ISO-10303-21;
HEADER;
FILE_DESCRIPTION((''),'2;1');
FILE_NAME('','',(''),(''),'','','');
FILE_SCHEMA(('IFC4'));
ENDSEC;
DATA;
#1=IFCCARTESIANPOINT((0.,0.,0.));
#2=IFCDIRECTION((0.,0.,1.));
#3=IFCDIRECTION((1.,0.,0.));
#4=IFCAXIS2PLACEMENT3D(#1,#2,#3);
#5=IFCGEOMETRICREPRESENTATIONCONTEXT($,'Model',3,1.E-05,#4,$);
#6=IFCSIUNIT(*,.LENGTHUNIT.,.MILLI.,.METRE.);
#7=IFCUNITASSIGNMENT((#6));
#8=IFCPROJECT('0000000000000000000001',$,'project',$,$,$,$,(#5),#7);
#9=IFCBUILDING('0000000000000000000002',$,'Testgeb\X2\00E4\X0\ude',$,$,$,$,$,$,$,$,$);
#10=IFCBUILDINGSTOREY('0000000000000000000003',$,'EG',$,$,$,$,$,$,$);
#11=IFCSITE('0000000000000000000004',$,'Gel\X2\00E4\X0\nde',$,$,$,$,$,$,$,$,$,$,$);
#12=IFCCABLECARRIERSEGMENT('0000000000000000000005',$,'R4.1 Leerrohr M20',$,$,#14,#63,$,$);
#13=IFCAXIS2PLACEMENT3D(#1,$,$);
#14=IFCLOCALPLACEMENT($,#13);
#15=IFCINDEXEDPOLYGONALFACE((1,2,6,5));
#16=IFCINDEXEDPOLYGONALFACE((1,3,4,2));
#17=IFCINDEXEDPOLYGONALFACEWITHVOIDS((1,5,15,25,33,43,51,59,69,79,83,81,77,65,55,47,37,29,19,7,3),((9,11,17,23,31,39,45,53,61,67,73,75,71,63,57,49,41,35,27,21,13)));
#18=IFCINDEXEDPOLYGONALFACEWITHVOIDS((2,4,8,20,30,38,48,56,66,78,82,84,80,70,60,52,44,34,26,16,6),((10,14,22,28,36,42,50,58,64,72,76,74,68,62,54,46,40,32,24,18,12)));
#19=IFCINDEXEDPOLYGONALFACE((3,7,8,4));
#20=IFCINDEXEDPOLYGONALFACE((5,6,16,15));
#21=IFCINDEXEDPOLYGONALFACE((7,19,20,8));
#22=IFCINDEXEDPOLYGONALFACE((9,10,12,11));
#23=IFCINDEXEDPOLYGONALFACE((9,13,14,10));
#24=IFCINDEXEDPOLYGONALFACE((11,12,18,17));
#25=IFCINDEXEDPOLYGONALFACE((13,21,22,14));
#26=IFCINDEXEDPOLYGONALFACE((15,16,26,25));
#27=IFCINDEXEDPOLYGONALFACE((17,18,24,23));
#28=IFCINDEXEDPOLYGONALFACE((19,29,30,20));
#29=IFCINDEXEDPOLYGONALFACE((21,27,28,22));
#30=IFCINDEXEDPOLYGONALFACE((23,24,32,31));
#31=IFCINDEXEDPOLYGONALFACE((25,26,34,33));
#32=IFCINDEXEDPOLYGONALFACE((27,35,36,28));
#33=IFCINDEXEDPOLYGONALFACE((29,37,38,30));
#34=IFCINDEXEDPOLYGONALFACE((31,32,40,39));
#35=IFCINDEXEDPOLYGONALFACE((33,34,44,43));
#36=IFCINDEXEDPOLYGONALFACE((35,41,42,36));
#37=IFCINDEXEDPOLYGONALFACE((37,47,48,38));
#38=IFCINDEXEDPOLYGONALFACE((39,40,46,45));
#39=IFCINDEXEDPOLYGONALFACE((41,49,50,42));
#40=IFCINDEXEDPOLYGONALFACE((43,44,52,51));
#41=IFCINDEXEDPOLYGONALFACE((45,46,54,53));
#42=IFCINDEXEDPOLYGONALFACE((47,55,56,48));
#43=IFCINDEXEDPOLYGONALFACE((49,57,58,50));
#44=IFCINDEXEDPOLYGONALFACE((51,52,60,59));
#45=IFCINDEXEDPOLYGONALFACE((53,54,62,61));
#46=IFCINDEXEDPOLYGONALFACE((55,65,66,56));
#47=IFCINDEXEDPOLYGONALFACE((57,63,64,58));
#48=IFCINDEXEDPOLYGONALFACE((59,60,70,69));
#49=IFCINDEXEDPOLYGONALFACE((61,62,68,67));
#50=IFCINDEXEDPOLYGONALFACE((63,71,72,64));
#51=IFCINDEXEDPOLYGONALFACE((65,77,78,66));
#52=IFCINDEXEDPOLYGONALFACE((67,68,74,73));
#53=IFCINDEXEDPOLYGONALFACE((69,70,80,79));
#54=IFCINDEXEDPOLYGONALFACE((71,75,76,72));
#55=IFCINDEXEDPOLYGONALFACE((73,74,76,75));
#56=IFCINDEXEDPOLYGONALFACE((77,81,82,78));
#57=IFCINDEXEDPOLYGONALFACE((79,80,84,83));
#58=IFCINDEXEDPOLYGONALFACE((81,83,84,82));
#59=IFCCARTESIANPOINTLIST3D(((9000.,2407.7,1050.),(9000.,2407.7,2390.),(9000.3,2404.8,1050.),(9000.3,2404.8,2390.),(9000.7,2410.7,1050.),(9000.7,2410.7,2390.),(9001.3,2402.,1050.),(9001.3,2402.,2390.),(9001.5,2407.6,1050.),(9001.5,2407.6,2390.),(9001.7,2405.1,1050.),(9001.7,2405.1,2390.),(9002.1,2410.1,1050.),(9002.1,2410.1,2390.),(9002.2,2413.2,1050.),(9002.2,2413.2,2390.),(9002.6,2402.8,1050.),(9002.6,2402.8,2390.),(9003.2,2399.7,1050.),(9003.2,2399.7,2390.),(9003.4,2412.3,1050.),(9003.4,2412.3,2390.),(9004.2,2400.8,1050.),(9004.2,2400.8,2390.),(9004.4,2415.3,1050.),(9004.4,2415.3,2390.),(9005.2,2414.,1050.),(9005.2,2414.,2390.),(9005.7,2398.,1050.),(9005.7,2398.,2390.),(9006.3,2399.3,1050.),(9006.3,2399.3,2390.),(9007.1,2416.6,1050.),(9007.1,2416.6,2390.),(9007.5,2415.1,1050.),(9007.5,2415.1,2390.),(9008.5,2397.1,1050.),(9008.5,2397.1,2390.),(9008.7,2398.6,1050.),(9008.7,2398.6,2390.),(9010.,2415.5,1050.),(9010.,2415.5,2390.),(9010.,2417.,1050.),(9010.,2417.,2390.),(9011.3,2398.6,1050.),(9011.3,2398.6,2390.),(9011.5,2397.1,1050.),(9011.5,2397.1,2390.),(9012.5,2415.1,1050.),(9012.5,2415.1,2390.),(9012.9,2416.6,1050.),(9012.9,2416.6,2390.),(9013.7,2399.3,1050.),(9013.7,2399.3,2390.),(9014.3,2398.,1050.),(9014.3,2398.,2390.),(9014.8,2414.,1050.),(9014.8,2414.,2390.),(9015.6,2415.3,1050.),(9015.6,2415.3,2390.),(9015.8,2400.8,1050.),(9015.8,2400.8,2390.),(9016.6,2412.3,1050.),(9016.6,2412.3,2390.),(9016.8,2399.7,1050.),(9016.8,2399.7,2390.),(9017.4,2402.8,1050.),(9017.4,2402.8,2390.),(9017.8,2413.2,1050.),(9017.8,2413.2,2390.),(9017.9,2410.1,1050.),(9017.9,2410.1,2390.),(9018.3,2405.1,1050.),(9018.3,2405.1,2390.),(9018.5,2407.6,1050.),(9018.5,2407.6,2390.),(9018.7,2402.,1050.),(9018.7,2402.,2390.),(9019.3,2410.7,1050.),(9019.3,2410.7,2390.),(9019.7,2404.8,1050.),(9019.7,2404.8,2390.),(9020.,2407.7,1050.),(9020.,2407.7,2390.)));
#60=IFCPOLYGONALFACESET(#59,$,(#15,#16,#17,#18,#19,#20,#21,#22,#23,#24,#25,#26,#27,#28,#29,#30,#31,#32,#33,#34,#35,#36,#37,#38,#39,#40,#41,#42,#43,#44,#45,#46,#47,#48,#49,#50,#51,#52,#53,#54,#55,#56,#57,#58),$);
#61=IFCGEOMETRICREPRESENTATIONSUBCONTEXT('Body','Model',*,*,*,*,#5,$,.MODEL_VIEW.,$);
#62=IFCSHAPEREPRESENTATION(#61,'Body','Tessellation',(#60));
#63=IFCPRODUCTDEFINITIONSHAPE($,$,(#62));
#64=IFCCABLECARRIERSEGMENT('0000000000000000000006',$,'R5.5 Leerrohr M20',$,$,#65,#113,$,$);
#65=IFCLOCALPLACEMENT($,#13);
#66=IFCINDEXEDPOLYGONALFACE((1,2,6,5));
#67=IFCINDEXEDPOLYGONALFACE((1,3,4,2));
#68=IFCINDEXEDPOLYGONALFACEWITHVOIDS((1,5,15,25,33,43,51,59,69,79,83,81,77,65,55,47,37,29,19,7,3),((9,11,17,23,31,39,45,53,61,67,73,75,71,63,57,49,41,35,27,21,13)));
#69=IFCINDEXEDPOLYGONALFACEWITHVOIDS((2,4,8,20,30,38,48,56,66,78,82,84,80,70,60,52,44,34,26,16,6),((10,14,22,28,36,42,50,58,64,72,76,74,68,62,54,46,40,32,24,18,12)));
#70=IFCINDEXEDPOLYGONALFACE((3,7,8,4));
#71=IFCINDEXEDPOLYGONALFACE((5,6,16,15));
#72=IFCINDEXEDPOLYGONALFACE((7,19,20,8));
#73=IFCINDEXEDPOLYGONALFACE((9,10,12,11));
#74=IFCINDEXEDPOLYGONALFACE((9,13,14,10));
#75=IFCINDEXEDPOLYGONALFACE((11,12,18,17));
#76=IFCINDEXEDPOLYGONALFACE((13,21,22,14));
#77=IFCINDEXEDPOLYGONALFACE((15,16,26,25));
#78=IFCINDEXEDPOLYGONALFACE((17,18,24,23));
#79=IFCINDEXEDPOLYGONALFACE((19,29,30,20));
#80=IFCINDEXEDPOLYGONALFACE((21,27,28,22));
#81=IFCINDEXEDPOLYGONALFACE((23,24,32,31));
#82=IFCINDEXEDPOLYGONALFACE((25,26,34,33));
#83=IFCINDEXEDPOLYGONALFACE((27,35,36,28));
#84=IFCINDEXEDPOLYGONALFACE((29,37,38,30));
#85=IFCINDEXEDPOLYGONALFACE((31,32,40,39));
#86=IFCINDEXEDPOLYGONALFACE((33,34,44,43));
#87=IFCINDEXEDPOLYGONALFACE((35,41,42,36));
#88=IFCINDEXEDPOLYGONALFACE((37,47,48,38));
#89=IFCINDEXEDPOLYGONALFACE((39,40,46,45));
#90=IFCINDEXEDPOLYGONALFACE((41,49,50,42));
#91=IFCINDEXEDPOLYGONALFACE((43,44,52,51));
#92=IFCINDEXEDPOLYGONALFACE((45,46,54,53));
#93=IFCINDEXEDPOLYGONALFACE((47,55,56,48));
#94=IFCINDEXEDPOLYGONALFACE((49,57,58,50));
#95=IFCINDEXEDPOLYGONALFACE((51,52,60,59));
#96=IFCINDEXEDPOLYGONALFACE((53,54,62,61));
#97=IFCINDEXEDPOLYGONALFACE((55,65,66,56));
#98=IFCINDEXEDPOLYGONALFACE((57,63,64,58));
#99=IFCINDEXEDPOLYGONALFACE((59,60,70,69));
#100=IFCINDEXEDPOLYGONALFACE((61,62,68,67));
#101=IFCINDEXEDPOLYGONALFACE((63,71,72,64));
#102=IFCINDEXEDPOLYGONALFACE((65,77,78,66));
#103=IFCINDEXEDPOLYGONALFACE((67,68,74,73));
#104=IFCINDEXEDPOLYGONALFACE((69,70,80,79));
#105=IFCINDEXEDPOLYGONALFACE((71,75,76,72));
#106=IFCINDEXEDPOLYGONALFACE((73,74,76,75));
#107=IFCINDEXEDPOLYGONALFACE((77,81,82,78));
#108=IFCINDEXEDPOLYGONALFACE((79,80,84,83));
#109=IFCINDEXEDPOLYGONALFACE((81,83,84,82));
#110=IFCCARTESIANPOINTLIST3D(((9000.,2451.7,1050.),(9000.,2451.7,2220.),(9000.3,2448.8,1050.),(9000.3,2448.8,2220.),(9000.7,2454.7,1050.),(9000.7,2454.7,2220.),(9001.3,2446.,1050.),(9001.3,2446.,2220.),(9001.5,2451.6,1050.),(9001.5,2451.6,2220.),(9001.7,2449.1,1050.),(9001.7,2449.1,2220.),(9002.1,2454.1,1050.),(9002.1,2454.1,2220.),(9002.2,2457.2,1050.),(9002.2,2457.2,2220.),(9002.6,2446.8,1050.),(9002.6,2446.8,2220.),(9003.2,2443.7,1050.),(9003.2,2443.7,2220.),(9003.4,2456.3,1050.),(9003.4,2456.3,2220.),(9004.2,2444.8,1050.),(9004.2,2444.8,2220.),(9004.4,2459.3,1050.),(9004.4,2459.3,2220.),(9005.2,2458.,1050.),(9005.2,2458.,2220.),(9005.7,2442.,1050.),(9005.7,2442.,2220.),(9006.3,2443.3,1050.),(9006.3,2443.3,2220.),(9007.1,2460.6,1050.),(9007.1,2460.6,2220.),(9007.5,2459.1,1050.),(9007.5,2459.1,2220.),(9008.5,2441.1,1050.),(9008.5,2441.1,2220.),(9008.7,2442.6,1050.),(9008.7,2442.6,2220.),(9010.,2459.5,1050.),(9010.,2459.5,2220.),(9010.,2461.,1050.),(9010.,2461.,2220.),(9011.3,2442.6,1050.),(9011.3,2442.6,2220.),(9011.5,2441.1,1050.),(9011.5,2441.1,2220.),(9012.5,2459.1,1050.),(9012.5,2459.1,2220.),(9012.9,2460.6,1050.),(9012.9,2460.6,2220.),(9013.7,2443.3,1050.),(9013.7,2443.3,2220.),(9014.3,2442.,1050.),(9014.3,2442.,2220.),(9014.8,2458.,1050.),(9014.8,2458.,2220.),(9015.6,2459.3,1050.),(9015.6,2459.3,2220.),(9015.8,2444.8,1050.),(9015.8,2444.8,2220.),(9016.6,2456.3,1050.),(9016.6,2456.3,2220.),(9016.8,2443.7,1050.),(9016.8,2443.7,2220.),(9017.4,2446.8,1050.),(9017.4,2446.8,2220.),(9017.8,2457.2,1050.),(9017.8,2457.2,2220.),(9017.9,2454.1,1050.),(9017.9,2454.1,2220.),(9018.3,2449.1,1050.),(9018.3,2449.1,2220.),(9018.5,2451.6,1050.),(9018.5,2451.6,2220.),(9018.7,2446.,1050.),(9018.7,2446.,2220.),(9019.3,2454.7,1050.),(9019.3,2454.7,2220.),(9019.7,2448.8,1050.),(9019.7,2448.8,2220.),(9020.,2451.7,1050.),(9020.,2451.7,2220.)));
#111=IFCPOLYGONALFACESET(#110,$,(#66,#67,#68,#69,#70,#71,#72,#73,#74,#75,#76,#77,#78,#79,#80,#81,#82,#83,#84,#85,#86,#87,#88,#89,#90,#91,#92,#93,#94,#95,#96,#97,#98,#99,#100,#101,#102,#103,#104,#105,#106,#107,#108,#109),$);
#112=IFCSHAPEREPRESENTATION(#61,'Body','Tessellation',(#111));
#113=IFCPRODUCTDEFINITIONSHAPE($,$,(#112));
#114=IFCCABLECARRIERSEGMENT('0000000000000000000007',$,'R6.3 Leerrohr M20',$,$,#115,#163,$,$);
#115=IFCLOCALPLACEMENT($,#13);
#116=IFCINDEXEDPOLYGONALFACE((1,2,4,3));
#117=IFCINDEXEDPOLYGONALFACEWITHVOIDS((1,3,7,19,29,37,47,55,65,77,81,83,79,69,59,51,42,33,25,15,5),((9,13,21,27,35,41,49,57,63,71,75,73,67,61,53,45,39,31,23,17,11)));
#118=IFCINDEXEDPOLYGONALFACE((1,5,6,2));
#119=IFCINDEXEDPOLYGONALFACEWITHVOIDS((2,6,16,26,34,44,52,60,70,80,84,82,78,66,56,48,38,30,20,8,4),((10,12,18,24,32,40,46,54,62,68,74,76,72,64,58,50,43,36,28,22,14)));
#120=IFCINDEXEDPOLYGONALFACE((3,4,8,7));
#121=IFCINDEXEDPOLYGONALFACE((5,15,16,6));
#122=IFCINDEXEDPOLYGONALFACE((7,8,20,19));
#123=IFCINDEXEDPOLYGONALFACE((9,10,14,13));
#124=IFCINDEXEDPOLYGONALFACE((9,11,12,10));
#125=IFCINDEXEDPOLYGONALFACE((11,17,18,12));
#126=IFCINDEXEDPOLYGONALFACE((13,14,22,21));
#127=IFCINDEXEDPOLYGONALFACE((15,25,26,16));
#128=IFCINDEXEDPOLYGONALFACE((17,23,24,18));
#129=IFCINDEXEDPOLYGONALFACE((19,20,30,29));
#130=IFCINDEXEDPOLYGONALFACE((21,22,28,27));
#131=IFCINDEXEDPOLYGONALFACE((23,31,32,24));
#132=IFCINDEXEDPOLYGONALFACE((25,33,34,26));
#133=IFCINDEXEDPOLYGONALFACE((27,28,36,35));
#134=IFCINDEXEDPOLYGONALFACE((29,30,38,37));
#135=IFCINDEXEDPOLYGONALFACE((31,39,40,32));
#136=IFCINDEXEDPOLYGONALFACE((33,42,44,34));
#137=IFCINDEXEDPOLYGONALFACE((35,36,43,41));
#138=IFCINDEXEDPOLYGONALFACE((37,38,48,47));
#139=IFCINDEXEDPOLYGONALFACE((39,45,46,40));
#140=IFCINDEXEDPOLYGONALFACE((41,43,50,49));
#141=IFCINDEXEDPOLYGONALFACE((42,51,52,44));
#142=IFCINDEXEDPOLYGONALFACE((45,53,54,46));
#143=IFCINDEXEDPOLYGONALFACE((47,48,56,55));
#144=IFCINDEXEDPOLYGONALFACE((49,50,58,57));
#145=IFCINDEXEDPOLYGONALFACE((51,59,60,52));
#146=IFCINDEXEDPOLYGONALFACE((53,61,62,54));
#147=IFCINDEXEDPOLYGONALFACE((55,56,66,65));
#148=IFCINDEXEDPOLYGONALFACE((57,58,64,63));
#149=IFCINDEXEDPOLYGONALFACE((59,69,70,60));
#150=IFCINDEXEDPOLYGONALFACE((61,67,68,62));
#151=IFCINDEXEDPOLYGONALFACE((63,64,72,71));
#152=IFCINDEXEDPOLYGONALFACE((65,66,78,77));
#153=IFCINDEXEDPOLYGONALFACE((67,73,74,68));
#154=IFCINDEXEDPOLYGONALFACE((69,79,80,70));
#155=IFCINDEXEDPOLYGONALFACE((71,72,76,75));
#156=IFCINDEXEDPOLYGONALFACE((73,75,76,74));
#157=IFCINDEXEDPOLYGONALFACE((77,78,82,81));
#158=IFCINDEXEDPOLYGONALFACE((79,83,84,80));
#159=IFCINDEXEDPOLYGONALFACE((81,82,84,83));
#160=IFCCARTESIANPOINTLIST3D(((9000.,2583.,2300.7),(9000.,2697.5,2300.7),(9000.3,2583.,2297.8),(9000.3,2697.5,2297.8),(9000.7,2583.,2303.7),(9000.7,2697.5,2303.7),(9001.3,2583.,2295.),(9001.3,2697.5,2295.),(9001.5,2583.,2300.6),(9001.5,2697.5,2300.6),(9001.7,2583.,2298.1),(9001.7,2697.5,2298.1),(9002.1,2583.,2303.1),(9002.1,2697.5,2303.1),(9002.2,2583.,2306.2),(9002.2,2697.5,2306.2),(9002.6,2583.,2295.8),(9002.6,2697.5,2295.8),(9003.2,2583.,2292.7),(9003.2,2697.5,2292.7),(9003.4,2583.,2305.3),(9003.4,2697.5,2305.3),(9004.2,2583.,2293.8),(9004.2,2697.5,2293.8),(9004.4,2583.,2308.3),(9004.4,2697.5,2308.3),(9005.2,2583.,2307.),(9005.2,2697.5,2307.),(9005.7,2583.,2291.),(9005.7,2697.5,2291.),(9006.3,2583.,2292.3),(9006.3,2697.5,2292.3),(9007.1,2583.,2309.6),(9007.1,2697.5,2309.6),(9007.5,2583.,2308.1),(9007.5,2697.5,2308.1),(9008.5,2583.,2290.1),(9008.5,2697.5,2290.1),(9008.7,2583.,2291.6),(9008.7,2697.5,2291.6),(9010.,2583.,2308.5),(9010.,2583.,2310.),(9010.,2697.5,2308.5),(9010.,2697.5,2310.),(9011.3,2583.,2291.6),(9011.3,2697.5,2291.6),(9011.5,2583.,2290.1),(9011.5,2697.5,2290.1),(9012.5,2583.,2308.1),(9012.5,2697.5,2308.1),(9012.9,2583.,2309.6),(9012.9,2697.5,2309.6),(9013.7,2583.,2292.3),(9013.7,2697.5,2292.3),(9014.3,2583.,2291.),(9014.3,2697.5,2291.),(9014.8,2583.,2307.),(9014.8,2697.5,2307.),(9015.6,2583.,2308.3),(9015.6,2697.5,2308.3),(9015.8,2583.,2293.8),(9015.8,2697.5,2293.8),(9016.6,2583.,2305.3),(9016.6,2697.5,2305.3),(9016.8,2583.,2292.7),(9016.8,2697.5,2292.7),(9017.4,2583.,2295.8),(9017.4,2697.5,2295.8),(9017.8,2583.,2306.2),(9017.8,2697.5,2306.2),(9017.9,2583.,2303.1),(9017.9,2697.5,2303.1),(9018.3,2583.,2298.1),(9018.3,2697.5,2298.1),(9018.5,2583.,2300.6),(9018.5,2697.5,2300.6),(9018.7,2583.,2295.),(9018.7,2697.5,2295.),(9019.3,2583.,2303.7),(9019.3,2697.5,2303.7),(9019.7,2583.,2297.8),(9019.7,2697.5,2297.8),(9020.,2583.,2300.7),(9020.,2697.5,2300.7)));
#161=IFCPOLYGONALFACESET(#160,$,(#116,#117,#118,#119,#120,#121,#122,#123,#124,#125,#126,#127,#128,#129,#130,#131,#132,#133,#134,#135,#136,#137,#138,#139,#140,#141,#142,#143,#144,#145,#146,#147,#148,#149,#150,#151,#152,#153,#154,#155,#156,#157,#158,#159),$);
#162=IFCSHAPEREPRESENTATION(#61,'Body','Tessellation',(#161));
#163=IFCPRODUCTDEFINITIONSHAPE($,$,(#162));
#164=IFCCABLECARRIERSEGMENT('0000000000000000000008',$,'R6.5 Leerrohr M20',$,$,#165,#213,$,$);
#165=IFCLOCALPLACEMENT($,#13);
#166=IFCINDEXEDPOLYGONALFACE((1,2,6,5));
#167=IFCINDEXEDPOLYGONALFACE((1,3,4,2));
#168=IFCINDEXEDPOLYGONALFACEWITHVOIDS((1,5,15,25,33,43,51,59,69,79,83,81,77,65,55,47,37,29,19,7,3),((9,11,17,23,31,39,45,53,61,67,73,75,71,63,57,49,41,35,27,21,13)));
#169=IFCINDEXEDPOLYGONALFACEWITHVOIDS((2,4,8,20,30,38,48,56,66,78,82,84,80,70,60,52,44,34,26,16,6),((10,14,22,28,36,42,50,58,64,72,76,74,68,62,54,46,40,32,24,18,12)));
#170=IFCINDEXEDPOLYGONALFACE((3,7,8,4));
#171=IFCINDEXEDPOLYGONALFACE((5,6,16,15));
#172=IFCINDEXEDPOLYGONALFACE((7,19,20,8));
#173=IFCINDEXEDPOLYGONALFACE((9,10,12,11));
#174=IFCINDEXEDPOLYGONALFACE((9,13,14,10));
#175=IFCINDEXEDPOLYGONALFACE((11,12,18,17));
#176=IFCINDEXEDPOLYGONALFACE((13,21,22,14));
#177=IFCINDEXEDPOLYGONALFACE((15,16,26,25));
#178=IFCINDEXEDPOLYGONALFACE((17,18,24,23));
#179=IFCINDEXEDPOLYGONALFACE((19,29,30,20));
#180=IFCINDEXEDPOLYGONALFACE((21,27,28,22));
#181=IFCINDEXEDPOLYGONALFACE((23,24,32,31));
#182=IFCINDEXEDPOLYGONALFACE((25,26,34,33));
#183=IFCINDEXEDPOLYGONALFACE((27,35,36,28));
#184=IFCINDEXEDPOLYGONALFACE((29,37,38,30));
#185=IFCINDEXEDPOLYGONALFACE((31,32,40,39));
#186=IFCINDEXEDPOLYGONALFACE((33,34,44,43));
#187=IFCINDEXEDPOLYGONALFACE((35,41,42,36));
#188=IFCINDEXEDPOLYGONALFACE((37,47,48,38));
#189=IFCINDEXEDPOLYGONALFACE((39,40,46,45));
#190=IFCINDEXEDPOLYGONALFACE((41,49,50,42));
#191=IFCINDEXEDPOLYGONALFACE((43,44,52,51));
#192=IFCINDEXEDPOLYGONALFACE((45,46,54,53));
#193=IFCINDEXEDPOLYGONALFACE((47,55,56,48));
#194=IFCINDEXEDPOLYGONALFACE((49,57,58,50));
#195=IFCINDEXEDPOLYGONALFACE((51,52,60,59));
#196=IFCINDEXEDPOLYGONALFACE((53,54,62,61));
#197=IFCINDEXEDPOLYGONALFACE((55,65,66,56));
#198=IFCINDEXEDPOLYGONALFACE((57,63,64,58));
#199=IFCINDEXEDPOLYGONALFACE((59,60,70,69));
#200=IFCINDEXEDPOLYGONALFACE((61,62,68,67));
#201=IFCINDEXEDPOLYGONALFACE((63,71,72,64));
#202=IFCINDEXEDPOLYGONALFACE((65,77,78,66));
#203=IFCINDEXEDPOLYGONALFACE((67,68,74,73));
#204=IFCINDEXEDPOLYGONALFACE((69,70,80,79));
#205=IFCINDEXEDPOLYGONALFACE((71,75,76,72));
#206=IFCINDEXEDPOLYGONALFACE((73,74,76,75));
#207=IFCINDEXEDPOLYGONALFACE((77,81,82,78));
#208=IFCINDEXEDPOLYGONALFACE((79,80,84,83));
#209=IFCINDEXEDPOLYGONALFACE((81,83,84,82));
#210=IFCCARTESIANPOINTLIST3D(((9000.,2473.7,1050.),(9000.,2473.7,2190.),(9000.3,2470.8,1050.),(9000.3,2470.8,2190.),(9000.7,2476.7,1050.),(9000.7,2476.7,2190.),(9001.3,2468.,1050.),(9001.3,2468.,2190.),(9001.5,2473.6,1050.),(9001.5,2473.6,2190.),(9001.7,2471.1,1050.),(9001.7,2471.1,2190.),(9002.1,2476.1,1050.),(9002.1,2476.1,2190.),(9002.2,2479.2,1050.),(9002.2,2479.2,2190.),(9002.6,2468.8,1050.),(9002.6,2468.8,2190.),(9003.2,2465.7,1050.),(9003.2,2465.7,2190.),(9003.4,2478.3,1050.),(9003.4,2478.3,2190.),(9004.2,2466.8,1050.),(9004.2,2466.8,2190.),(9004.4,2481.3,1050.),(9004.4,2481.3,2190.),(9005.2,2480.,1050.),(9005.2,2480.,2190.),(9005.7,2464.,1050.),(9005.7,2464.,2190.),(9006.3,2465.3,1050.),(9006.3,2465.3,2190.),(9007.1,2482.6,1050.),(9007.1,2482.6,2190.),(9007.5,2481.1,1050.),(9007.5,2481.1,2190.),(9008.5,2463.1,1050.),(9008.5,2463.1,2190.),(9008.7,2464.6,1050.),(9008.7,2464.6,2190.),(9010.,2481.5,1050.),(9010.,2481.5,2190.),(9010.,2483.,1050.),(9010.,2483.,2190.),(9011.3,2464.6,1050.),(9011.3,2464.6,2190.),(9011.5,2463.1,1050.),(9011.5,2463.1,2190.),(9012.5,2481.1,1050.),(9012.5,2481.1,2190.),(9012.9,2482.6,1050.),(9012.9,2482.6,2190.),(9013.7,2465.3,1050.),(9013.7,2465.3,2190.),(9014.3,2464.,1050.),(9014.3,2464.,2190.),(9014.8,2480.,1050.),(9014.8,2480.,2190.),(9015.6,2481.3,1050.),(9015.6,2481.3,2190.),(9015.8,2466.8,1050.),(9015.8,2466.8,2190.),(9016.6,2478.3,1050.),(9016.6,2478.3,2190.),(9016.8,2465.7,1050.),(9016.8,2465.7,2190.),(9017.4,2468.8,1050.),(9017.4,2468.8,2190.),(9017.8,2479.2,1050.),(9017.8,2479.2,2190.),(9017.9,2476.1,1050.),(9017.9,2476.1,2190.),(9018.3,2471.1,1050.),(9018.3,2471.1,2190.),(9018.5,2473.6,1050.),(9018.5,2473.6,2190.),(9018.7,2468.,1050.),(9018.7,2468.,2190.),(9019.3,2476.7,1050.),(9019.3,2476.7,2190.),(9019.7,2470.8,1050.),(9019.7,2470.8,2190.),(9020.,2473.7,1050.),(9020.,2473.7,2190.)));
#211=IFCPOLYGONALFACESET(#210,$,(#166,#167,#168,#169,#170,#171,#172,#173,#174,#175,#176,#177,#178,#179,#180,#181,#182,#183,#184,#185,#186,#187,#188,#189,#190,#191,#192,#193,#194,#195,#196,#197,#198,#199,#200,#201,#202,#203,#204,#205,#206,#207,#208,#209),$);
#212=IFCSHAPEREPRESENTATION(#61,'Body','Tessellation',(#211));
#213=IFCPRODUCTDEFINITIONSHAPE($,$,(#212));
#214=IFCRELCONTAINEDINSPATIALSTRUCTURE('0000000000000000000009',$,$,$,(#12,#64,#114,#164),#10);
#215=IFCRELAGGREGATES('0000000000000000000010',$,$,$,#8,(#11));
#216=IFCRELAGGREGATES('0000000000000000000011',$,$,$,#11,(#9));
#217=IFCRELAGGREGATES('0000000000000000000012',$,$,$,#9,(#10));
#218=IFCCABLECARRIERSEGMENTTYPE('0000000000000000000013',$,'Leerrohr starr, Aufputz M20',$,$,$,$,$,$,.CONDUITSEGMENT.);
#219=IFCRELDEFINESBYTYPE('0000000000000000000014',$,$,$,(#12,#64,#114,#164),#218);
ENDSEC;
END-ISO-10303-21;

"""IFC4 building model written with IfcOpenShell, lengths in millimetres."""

from ifc_helpers import new_model, si_unit, frame, origin_with_axes, place, context, subcontext, project, spatial, hollow_circle, extrude, type_object, element, save


model = new_model("IFC4")

# Units and contexts
model_context = context("Model", 3, precision=1e-05, world=origin_with_axes())
body_context = subcontext(model_context, "Body", "Model", "MODEL_VIEW")
ifc_project = project(units=[si_unit("LENGTHUNIT", "METRE", prefix="MILLI")], contexts=[model_context])

# Site, building, storey
site = spatial("IfcSite", under=ifc_project, Name="Gelände")
building = spatial("IfcBuilding", under=site, Name="Testgebäude")
storey = spatial("IfcBuildingStorey", under=building, Name="EG")

# Cable carrier segments
cable_carrier_segment_type_1 = type_object("IfcCableCarrierSegmentType", Name="Leerrohr starr, Aufputz M20", PredefinedType="CONDUITSEGMENT")
for number, where, z_axis, x_axis, name in (
    (1, (9010.0, 2407.0, 1050.0), (0.0, 0.0, 1.0), (0.0, 1.0, 0.0), "R4.1 Leerrohr M20"),
):
    element("IfcCableCarrierSegment", number, at=place(None, frame(where, z_axis=z_axis, x_axis=x_axis)), inside=storey, type_object=cable_carrier_segment_type_1, Name=name, context=body_context, shape_type="SweptSolid", body=[
        extrude(hollow_circle(Radius=10.0, WallThickness=1.5), None, (0.0, 0.0, 1.0), 1340.0),
    ])
cable_carrier_segment_1_placement = place(None, frame((9010.0, 2451.0, 2220.0), z_axis=(0.0, 0.0, -1.0), x_axis=(0.0, 1.0, 0.0)))
element("IfcCableCarrierSegment", 2, at=cable_carrier_segment_1_placement, inside=storey, type_object=cable_carrier_segment_type_1, Name="R5.5 Leerrohr M20", context=body_context, shape_type="SweptSolid", body=[
    extrude(hollow_circle(Radius=10.0, WallThickness=1.5), None, (0.0, 0.0, 1.0), 1170.0),
])
cable_carrier_segment_2_placement = place(None, frame((9010.0, 2697.5, 2300.0), z_axis=(0.0, -1.0, 0.0), x_axis=(0.0, 0.0, 1.0)))
element("IfcCableCarrierSegment", 3, at=cable_carrier_segment_2_placement, inside=storey, type_object=cable_carrier_segment_type_1, Name="R6.3 Leerrohr M20", context=body_context, shape_type="SweptSolid", body=[
    extrude(hollow_circle(Radius=10.0, WallThickness=1.5), None, (0.0, 0.0, 1.0), 114.5),
])
cable_carrier_segment_3_placement = place(None, frame((9010.0, 2473.0, 2190.0), z_axis=(0.0, 0.0, -1.0), x_axis=(0.0, 1.0, 0.0)))
element("IfcCableCarrierSegment", 4, at=cable_carrier_segment_3_placement, inside=storey, type_object=cable_carrier_segment_type_1, Name="R6.5 Leerrohr M20", context=body_context, shape_type="SweptSolid", body=[
    extrude(hollow_circle(Radius=10.0, WallThickness=1.5), None, (0.0, 0.0, 1.0), 1140.0),
])

save(model, "model.ifc")
